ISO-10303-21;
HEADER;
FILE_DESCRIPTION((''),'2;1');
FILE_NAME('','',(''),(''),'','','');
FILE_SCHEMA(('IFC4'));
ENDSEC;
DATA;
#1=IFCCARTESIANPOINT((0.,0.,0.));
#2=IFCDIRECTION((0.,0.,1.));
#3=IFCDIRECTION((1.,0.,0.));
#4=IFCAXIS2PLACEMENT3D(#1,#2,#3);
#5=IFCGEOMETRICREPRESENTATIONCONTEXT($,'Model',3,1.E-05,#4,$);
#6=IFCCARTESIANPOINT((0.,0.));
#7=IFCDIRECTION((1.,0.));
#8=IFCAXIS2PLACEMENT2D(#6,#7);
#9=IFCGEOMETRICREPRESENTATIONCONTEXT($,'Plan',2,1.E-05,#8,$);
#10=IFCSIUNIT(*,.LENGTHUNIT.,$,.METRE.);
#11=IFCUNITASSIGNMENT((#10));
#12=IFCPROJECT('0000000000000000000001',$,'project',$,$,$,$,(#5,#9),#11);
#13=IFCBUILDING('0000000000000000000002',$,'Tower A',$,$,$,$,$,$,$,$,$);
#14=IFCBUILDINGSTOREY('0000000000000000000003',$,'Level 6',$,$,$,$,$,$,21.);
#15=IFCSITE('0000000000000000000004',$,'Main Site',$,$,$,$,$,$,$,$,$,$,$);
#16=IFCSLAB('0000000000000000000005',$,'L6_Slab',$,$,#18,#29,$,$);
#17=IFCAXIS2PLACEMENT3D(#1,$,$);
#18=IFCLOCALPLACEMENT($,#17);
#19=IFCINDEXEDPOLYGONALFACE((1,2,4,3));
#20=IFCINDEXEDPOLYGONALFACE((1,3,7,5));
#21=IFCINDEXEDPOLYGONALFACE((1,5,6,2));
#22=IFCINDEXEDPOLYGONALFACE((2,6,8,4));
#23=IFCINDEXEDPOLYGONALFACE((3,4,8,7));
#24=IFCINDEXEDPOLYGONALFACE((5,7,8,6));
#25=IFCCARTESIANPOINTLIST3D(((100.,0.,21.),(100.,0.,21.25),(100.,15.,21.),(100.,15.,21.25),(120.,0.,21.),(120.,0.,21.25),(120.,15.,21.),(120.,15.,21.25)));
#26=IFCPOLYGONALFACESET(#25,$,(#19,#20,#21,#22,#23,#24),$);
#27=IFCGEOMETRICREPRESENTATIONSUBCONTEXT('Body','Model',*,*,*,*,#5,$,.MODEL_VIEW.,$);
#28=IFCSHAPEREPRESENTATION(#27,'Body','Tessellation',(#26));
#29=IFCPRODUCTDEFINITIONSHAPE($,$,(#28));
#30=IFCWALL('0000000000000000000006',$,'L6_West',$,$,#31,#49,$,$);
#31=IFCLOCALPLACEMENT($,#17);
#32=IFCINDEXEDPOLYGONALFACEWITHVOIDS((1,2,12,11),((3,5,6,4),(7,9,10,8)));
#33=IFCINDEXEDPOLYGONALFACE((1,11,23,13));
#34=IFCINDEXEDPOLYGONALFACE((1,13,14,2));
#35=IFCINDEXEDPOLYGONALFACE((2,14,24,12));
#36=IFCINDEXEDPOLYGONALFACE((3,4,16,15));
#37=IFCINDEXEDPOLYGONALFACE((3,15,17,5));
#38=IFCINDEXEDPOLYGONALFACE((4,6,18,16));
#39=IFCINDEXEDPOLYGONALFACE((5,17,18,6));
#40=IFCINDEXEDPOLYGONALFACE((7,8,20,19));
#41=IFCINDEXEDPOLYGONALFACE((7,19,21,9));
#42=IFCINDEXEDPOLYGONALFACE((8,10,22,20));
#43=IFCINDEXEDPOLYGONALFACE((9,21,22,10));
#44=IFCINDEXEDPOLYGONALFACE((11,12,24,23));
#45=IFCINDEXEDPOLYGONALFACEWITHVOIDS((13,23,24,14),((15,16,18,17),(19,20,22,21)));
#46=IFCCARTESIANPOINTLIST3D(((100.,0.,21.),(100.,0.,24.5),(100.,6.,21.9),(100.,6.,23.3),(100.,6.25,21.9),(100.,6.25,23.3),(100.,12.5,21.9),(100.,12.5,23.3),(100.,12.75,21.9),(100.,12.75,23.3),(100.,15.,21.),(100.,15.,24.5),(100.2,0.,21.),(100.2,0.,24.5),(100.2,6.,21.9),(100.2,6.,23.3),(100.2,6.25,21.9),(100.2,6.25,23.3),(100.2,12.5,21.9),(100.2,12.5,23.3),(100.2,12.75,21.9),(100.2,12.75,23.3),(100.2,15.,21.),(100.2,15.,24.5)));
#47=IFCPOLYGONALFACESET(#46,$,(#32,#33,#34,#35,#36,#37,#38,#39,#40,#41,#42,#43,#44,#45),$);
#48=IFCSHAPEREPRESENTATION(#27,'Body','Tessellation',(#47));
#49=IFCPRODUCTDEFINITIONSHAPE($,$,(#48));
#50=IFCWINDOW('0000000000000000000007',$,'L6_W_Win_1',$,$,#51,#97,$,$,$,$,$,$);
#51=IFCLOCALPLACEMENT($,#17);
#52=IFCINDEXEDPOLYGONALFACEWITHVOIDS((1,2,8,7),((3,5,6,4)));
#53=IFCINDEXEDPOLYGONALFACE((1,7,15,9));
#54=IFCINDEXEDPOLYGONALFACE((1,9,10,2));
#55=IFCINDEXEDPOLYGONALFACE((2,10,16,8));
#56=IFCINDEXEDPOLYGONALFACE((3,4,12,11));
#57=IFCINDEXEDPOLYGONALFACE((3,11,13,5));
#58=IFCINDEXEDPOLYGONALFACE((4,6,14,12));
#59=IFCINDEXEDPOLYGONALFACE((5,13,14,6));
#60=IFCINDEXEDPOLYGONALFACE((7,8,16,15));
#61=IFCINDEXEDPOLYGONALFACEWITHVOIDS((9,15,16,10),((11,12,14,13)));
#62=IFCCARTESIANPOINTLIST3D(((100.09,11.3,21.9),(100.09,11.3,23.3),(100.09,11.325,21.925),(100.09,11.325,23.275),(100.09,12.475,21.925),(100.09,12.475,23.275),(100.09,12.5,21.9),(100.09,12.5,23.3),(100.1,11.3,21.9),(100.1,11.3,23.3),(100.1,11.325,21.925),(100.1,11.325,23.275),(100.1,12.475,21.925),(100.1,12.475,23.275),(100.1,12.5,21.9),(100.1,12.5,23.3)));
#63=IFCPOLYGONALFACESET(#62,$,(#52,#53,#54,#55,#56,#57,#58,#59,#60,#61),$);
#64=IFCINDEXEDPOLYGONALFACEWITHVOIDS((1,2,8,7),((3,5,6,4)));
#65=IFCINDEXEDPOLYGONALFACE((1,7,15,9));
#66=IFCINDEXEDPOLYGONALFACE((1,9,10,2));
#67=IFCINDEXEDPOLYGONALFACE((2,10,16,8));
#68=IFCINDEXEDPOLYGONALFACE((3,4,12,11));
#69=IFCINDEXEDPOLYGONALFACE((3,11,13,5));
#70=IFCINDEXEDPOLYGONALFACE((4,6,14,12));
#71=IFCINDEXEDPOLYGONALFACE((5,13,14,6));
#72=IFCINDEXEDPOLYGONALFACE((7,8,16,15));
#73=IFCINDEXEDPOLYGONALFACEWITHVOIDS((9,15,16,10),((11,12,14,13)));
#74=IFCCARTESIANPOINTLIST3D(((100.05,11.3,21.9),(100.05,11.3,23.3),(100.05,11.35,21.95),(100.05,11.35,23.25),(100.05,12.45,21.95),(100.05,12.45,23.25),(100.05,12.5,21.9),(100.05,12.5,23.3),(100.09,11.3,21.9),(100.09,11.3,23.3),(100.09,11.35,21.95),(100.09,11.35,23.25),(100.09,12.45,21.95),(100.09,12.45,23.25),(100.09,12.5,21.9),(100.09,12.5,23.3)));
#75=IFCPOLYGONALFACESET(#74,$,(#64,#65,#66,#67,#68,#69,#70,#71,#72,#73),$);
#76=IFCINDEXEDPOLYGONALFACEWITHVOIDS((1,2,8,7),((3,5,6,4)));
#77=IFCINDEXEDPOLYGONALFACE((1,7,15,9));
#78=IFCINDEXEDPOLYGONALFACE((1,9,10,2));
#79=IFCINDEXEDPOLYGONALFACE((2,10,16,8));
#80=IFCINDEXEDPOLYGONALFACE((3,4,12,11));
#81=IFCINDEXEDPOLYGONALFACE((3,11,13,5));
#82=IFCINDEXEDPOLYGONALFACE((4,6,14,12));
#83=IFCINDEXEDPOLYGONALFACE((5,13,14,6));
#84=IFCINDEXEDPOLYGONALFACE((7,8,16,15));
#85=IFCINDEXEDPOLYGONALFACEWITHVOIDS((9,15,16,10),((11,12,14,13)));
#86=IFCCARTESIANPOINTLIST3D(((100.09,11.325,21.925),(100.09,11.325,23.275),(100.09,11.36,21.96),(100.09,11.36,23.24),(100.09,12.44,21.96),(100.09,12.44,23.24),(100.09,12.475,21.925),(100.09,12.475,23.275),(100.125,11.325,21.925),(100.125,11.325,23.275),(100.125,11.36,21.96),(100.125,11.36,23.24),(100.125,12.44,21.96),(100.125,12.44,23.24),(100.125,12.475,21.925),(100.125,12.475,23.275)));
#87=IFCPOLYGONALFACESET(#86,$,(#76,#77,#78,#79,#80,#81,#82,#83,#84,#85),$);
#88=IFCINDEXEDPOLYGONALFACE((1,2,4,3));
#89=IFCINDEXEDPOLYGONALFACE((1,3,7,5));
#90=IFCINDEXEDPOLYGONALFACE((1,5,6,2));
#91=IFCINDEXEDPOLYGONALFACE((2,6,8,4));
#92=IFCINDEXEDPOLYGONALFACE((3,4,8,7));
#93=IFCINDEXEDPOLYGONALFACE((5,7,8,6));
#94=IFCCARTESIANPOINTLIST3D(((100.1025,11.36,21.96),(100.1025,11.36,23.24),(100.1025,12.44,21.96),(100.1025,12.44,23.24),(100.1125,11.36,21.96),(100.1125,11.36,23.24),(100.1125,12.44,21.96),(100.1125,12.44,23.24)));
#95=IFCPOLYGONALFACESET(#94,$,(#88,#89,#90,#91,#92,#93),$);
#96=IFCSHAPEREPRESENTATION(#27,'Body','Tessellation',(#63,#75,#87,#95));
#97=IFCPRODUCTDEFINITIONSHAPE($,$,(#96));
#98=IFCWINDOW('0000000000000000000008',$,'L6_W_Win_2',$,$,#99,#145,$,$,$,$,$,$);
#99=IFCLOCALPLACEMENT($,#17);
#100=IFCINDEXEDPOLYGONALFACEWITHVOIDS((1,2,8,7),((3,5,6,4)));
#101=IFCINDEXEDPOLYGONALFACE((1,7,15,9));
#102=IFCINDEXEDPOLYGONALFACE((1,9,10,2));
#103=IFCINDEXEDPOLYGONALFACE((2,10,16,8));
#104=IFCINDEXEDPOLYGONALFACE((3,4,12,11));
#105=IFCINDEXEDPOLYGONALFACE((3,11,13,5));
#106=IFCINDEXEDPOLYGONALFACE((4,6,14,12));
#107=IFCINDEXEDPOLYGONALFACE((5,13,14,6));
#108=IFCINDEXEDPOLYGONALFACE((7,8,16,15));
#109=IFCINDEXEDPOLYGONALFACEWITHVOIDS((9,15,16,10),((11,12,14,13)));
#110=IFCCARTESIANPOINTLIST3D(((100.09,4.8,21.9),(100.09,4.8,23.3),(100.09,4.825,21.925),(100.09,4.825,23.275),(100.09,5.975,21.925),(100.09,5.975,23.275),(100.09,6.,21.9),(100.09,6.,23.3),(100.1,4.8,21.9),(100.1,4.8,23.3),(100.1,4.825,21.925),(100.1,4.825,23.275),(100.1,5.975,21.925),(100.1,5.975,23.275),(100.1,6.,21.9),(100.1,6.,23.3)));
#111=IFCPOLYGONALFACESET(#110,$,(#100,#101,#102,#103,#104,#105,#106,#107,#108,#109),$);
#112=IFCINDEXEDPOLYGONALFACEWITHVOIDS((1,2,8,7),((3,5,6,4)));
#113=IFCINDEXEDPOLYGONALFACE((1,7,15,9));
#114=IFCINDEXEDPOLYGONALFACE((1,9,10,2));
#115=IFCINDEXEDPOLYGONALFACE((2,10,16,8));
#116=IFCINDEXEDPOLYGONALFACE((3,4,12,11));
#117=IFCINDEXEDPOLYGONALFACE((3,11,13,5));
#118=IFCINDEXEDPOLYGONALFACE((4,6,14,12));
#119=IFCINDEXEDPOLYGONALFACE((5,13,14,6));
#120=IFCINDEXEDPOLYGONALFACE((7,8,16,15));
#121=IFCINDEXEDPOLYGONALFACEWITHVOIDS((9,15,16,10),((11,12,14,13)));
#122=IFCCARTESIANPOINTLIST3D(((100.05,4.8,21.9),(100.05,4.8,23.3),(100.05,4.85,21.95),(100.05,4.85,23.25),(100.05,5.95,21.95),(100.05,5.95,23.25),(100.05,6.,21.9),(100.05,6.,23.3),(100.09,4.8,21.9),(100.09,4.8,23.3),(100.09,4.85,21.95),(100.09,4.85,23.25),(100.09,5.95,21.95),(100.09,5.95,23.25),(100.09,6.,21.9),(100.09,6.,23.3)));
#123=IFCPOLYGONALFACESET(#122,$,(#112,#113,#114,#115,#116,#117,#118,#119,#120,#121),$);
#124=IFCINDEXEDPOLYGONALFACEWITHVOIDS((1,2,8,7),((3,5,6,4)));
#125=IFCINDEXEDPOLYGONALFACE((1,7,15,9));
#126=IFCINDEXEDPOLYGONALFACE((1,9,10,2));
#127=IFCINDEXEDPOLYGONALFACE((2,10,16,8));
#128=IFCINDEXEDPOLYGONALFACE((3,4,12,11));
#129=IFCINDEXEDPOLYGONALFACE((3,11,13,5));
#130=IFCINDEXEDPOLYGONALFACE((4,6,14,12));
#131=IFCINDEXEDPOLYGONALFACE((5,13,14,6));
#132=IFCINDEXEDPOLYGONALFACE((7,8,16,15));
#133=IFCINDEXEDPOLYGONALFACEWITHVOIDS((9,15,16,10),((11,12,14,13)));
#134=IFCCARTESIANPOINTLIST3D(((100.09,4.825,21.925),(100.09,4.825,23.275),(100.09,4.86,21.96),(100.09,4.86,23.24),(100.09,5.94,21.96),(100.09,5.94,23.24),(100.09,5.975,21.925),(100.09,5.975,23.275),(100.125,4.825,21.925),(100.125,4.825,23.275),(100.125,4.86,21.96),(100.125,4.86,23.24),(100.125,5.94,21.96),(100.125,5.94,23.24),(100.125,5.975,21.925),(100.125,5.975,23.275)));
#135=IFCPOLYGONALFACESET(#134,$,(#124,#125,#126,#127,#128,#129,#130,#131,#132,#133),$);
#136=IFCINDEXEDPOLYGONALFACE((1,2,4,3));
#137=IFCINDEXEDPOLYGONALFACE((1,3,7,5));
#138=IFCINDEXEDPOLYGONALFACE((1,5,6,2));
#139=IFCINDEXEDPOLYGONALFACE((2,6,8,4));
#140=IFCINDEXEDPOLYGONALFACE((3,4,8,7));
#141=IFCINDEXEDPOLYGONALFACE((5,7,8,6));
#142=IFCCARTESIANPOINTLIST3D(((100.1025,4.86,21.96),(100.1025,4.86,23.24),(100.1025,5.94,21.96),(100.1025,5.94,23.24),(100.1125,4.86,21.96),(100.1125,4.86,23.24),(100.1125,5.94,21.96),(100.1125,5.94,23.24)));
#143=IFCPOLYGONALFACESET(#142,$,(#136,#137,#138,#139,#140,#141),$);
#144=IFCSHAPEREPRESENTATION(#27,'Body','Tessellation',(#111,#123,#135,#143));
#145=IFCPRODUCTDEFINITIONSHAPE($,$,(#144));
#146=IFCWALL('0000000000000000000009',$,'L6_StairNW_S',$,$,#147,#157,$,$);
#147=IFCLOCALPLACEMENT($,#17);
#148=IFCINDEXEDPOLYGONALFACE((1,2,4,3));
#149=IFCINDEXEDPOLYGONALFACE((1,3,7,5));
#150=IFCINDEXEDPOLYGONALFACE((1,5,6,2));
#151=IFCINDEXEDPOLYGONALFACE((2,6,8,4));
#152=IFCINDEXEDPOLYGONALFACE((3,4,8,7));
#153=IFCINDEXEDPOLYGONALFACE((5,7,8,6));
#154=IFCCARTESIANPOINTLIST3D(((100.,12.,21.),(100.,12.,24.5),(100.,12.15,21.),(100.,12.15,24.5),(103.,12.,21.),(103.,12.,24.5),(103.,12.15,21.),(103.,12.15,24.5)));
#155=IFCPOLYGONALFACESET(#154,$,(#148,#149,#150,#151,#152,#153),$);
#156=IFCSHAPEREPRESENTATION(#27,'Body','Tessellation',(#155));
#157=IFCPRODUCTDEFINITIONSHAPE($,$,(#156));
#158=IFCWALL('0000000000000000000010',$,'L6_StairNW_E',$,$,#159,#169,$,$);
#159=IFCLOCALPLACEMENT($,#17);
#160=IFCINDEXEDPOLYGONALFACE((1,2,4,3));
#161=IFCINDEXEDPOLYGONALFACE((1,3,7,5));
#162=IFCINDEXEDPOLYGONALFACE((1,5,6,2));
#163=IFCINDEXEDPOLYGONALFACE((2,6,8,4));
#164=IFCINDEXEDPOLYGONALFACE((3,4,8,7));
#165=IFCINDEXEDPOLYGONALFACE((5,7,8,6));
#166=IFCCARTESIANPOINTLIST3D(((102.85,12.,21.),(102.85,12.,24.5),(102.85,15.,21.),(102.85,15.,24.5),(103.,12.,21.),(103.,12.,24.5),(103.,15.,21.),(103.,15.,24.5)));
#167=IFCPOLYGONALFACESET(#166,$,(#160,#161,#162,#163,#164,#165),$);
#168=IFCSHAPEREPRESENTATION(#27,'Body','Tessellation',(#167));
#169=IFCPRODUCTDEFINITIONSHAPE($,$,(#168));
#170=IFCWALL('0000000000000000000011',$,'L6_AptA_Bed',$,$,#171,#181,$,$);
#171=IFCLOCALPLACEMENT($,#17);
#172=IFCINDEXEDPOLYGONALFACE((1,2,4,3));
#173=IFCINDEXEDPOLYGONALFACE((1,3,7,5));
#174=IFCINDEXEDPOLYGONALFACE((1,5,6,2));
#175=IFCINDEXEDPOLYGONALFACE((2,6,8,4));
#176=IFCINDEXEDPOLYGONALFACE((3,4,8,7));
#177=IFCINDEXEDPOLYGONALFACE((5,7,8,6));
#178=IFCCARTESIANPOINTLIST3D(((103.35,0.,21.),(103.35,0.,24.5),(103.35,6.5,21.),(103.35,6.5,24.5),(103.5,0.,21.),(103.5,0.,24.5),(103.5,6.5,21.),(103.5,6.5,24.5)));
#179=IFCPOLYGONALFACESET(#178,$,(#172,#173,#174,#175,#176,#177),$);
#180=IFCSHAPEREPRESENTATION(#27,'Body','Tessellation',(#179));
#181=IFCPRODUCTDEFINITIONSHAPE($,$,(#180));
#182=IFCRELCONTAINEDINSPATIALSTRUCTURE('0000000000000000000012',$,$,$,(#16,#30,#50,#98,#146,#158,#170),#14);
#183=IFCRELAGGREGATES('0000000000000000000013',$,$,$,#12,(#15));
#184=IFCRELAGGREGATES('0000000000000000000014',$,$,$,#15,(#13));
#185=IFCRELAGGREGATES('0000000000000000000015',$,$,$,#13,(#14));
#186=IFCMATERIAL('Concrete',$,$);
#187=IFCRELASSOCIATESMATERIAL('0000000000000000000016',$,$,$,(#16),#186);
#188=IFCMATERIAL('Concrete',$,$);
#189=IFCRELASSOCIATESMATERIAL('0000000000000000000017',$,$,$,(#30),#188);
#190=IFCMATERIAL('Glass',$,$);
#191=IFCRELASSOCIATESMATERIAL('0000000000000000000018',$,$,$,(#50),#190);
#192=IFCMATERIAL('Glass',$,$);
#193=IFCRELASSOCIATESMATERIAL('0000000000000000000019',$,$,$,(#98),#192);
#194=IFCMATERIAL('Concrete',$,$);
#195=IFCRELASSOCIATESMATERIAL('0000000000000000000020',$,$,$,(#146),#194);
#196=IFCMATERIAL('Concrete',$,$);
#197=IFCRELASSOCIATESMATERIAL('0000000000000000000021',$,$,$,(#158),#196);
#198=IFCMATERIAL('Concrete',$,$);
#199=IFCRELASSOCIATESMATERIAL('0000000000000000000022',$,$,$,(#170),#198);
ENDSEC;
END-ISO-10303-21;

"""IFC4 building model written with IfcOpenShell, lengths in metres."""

from ifc_helpers import new_model, si_unit, frame, origin_with_axes, origin_2d_with_axis, place, context, subcontext, project, spatial, line, indexed_curve, outline, extrude, material, element, fill, save


model = new_model("IFC4")

# Units and contexts
model_context = context("Model", 3, precision=1e-05, world=origin_with_axes())
plan_context = context("Plan", 2, precision=1e-05, world=origin_2d_with_axis())
body_context = subcontext(model_context, "Body", "Model", "MODEL_VIEW")
ifc_project = project(units=[si_unit("LENGTHUNIT", "METRE")], contexts=[model_context, plan_context])

# Site, building, storey
site = spatial("IfcSite", under=ifc_project, Name="Main Site")
building = spatial("IfcBuilding", under=site, Name="Tower A")
storey = spatial("IfcBuildingStorey", under=building, Name="Level 6", Elevation=21.0)

# Slab
ifc_material_1 = material(Name="Concrete")
slab_placement = place(None, frame((100.0, 0.0, 21.0), z_axis=(0.0, 0.0, 1.0), x_axis=(1.0, 0.0, 0.0)))
element("IfcSlab", 1, at=slab_placement, inside=storey, material=ifc_material_1, Name="L6_Slab", context=body_context, shape_type="SweptSolid", body=[
    extrude(outline(indexed_curve([(0.0, 0.0), (20.0, 0.0), (20.0, 15.0), (0.0, 15.0)])), None, (0.0, 0.0, 1.0), 0.25),
])

# Wall, openings, windows
ifc_material_2 = material(Name="Concrete")
wall_1_placement = place(None, frame((100.0, 15.0, 21.0), z_axis=(0.0, 0.0, 1.0), x_axis=(0.0, -1.0, 0.0)))
wall_1 = element("IfcWall", 2, at=wall_1_placement, inside=storey, material=ifc_material_2, Name="L6_West", context=body_context, shape_type="SweptSolid", body=[
    extrude(outline(indexed_curve([(0.0, 0.0), (0.0, 0.2), (15.0, 0.2), (15.0, 0.0), (0.0, 0.0)], self_intersect=False)), origin_with_axes(), (0.0, 0.0, 1.0), 3.5),
])
opening_1_placement = place(wall_1_placement, frame((2.5, 0.0, 0.9), z_axis=(0.0, 0.0, 1.0), x_axis=(0.0, 1.0, 0.0)))
opening_1 = element("IfcOpeningElement", 3, at=opening_1_placement, cuts=wall_1, context=body_context, shape_type="SweptSolid", body=[
    extrude(outline(indexed_curve([(0.0, 0.0), (0.0, 0.25), (1.2, 0.25), (1.2, 0.0), (0.0, 0.0)], self_intersect=False)), origin_with_axes(), (0.0, 0.0, 1.0), 1.4),
])
opening_2_placement = place(wall_1_placement, frame((9.0, 0.0, 0.9), z_axis=(0.0, 0.0, 1.0), x_axis=(0.0, 1.0, 0.0)))
opening_2 = element("IfcOpeningElement", 4, at=opening_2_placement, cuts=wall_1, context=body_context, shape_type="SweptSolid", body=[
    extrude(outline(indexed_curve([(0.0, 0.0), (0.0, 0.25), (1.2, 0.25), (1.2, 0.0), (0.0, 0.0)], self_intersect=False)), origin_with_axes(), (0.0, 0.0, 1.0), 1.4),
])
ifc_material_3 = material(Name="Glass")
window_1_placement = place(None, frame((100.0, 12.5, 21.9), z_axis=(0.0, 0.0, 1.0), x_axis=(0.0, -1.0, 0.0)))
window_1 = element("IfcWindow", 5, at=window_1_placement, inside=storey, material=ifc_material_3, Name="L6_W_Win_1", context=body_context, shape_type="SweptSolid", body=[
    extrude(outline(indexed_curve([(0.0, 0.0), (1.2, 0.0), (1.2, 1.4), (0.0, 1.4)], segments=[line(1, 2, 3, 4, 1)]), holes=[indexed_curve([(0.025, 0.025), (1.175, 0.025), (1.175, 1.375), (0.025, 1.375)], segments=[line(1, 2, 3, 4, 1)])]), frame((0.0, 0.09, 0.0), z_axis=(0.0, -1.0, 0.0), x_axis=(1.0, 0.0, 0.0)), (0.0, 0.0, -1.0), 0.01),
    extrude(outline(indexed_curve([(0.0, 0.0), (1.2, 0.0), (1.2, 1.4), (0.0, 1.4)], segments=[line(1, 2, 3, 4, 1)]), holes=[indexed_curve([(0.05, 0.05), (1.15, 0.05), (1.15, 1.35), (0.05, 1.35)], segments=[line(1, 2, 3, 4, 1)])]), frame((0.0, 0.05, 0.0), z_axis=(0.0, -1.0, 0.0), x_axis=(1.0, 0.0, 0.0)), (0.0, 0.0, -1.0), 0.04),
    extrude(outline(indexed_curve([(0.0, 0.0), (1.15, 0.0), (1.15, 1.35), (0.0, 1.35)], segments=[line(1, 2, 3, 4, 1)]), holes=[indexed_curve([(0.035, 0.035), (1.115, 0.035), (1.115, 1.315), (0.035, 1.315)], segments=[line(1, 2, 3, 4, 1)])]), frame((0.025, 0.09, 0.025), z_axis=(0.0, -1.0, 0.0), x_axis=(1.0, 0.0, 0.0)), (0.0, 0.0, -1.0), 0.035),
    extrude(outline(indexed_curve([(0.035, 0.035), (1.115, 0.035), (1.115, 1.315), (0.035, 1.315)], segments=[line(1, 2, 3, 4, 1)])), frame((0.025, 0.1025, 0.025), z_axis=(0.0, -1.0, 0.0), x_axis=(1.0, 0.0, 0.0)), (0.0, 0.0, -1.0), 0.01),
])
fill(opening_1, window_1)
ifc_material_4 = material(Name="Glass")
window_2_placement = place(None, frame((100.0, 6.0, 21.9), z_axis=(0.0, 0.0, 1.0), x_axis=(0.0, -1.0, 0.0)))
window_2 = element("IfcWindow", 6, at=window_2_placement, inside=storey, material=ifc_material_4, Name="L6_W_Win_2", context=body_context, shape_type="SweptSolid", body=[
    extrude(outline(indexed_curve([(0.0, 0.0), (1.2, 0.0), (1.2, 1.4), (0.0, 1.4)], segments=[line(1, 2, 3, 4, 1)]), holes=[indexed_curve([(0.025, 0.025), (1.175, 0.025), (1.175, 1.375), (0.025, 1.375)], segments=[line(1, 2, 3, 4, 1)])]), frame((0.0, 0.09, 0.0), z_axis=(0.0, -1.0, 0.0), x_axis=(1.0, 0.0, 0.0)), (0.0, 0.0, -1.0), 0.01),
    extrude(outline(indexed_curve([(0.0, 0.0), (1.2, 0.0), (1.2, 1.4), (0.0, 1.4)], segments=[line(1, 2, 3, 4, 1)]), holes=[indexed_curve([(0.05, 0.05), (1.15, 0.05), (1.15, 1.35), (0.05, 1.35)], segments=[line(1, 2, 3, 4, 1)])]), frame((0.0, 0.05, 0.0), z_axis=(0.0, -1.0, 0.0), x_axis=(1.0, 0.0, 0.0)), (0.0, 0.0, -1.0), 0.04),
    extrude(outline(indexed_curve([(0.0, 0.0), (1.15, 0.0), (1.15, 1.35), (0.0, 1.35)], segments=[line(1, 2, 3, 4, 1)]), holes=[indexed_curve([(0.035, 0.035), (1.115, 0.035), (1.115, 1.315), (0.035, 1.315)], segments=[line(1, 2, 3, 4, 1)])]), frame((0.025, 0.09, 0.025), z_axis=(0.0, -1.0, 0.0), x_axis=(1.0, 0.0, 0.0)), (0.0, 0.0, -1.0), 0.035),
    extrude(outline(indexed_curve([(0.035, 0.035), (1.115, 0.035), (1.115, 1.315), (0.035, 1.315)], segments=[line(1, 2, 3, 4, 1)])), frame((0.025, 0.1025, 0.025), z_axis=(0.0, -1.0, 0.0), x_axis=(1.0, 0.0, 0.0)), (0.0, 0.0, -1.0), 0.01),
])
fill(opening_2, window_2)

# Walls
ifc_material_5 = material(Name="Concrete")
wall_2_placement = place(None, frame((100.0, 12.0, 21.0), z_axis=(0.0, 0.0, 1.0), x_axis=(1.0, 0.0, 0.0)))
element("IfcWall", 7, at=wall_2_placement, inside=storey, material=ifc_material_5, Name="L6_StairNW_S", context=body_context, shape_type="SweptSolid", body=[
    extrude(outline(indexed_curve([(0.0, 0.0), (0.0, 0.15), (3.0, 0.15), (3.0, 0.0), (0.0, 0.0)], self_intersect=False)), origin_with_axes(), (0.0, 0.0, 1.0), 3.5),
])
ifc_material_6 = material(Name="Concrete")
wall_3_placement = place(None, frame((103.0, 12.0, 21.0), z_axis=(0.0, 0.0, 1.0), x_axis=(0.0, 1.0, 0.0)))
element("IfcWall", 8, at=wall_3_placement, inside=storey, material=ifc_material_6, Name="L6_StairNW_E", context=body_context, shape_type="SweptSolid", body=[
    extrude(outline(indexed_curve([(0.0, 0.0), (0.0, 0.15), (3.0, 0.15), (3.0, 0.0), (0.0, 0.0)], self_intersect=False)), origin_with_axes(), (0.0, 0.0, 1.0), 3.5),
])

# Wall
ifc_material_7 = material(Name="Concrete")
wall_4_placement = place(None, frame((103.5, 0.0, 21.0), z_axis=(0.0, 0.0, 1.0), x_axis=(0.0, 1.0, 0.0)))
element("IfcWall", 9, at=wall_4_placement, inside=storey, material=ifc_material_7, Name="L6_AptA_Bed", context=body_context, shape_type="SweptSolid", body=[
    extrude(outline(indexed_curve([(0.0, 0.0), (0.0, 0.15), (6.5, 0.15), (6.5, 0.0), (0.0, 0.0)], self_intersect=False)), origin_with_axes(), (0.0, 0.0, 1.0), 3.5),
])

save(model, "model.ifc")
